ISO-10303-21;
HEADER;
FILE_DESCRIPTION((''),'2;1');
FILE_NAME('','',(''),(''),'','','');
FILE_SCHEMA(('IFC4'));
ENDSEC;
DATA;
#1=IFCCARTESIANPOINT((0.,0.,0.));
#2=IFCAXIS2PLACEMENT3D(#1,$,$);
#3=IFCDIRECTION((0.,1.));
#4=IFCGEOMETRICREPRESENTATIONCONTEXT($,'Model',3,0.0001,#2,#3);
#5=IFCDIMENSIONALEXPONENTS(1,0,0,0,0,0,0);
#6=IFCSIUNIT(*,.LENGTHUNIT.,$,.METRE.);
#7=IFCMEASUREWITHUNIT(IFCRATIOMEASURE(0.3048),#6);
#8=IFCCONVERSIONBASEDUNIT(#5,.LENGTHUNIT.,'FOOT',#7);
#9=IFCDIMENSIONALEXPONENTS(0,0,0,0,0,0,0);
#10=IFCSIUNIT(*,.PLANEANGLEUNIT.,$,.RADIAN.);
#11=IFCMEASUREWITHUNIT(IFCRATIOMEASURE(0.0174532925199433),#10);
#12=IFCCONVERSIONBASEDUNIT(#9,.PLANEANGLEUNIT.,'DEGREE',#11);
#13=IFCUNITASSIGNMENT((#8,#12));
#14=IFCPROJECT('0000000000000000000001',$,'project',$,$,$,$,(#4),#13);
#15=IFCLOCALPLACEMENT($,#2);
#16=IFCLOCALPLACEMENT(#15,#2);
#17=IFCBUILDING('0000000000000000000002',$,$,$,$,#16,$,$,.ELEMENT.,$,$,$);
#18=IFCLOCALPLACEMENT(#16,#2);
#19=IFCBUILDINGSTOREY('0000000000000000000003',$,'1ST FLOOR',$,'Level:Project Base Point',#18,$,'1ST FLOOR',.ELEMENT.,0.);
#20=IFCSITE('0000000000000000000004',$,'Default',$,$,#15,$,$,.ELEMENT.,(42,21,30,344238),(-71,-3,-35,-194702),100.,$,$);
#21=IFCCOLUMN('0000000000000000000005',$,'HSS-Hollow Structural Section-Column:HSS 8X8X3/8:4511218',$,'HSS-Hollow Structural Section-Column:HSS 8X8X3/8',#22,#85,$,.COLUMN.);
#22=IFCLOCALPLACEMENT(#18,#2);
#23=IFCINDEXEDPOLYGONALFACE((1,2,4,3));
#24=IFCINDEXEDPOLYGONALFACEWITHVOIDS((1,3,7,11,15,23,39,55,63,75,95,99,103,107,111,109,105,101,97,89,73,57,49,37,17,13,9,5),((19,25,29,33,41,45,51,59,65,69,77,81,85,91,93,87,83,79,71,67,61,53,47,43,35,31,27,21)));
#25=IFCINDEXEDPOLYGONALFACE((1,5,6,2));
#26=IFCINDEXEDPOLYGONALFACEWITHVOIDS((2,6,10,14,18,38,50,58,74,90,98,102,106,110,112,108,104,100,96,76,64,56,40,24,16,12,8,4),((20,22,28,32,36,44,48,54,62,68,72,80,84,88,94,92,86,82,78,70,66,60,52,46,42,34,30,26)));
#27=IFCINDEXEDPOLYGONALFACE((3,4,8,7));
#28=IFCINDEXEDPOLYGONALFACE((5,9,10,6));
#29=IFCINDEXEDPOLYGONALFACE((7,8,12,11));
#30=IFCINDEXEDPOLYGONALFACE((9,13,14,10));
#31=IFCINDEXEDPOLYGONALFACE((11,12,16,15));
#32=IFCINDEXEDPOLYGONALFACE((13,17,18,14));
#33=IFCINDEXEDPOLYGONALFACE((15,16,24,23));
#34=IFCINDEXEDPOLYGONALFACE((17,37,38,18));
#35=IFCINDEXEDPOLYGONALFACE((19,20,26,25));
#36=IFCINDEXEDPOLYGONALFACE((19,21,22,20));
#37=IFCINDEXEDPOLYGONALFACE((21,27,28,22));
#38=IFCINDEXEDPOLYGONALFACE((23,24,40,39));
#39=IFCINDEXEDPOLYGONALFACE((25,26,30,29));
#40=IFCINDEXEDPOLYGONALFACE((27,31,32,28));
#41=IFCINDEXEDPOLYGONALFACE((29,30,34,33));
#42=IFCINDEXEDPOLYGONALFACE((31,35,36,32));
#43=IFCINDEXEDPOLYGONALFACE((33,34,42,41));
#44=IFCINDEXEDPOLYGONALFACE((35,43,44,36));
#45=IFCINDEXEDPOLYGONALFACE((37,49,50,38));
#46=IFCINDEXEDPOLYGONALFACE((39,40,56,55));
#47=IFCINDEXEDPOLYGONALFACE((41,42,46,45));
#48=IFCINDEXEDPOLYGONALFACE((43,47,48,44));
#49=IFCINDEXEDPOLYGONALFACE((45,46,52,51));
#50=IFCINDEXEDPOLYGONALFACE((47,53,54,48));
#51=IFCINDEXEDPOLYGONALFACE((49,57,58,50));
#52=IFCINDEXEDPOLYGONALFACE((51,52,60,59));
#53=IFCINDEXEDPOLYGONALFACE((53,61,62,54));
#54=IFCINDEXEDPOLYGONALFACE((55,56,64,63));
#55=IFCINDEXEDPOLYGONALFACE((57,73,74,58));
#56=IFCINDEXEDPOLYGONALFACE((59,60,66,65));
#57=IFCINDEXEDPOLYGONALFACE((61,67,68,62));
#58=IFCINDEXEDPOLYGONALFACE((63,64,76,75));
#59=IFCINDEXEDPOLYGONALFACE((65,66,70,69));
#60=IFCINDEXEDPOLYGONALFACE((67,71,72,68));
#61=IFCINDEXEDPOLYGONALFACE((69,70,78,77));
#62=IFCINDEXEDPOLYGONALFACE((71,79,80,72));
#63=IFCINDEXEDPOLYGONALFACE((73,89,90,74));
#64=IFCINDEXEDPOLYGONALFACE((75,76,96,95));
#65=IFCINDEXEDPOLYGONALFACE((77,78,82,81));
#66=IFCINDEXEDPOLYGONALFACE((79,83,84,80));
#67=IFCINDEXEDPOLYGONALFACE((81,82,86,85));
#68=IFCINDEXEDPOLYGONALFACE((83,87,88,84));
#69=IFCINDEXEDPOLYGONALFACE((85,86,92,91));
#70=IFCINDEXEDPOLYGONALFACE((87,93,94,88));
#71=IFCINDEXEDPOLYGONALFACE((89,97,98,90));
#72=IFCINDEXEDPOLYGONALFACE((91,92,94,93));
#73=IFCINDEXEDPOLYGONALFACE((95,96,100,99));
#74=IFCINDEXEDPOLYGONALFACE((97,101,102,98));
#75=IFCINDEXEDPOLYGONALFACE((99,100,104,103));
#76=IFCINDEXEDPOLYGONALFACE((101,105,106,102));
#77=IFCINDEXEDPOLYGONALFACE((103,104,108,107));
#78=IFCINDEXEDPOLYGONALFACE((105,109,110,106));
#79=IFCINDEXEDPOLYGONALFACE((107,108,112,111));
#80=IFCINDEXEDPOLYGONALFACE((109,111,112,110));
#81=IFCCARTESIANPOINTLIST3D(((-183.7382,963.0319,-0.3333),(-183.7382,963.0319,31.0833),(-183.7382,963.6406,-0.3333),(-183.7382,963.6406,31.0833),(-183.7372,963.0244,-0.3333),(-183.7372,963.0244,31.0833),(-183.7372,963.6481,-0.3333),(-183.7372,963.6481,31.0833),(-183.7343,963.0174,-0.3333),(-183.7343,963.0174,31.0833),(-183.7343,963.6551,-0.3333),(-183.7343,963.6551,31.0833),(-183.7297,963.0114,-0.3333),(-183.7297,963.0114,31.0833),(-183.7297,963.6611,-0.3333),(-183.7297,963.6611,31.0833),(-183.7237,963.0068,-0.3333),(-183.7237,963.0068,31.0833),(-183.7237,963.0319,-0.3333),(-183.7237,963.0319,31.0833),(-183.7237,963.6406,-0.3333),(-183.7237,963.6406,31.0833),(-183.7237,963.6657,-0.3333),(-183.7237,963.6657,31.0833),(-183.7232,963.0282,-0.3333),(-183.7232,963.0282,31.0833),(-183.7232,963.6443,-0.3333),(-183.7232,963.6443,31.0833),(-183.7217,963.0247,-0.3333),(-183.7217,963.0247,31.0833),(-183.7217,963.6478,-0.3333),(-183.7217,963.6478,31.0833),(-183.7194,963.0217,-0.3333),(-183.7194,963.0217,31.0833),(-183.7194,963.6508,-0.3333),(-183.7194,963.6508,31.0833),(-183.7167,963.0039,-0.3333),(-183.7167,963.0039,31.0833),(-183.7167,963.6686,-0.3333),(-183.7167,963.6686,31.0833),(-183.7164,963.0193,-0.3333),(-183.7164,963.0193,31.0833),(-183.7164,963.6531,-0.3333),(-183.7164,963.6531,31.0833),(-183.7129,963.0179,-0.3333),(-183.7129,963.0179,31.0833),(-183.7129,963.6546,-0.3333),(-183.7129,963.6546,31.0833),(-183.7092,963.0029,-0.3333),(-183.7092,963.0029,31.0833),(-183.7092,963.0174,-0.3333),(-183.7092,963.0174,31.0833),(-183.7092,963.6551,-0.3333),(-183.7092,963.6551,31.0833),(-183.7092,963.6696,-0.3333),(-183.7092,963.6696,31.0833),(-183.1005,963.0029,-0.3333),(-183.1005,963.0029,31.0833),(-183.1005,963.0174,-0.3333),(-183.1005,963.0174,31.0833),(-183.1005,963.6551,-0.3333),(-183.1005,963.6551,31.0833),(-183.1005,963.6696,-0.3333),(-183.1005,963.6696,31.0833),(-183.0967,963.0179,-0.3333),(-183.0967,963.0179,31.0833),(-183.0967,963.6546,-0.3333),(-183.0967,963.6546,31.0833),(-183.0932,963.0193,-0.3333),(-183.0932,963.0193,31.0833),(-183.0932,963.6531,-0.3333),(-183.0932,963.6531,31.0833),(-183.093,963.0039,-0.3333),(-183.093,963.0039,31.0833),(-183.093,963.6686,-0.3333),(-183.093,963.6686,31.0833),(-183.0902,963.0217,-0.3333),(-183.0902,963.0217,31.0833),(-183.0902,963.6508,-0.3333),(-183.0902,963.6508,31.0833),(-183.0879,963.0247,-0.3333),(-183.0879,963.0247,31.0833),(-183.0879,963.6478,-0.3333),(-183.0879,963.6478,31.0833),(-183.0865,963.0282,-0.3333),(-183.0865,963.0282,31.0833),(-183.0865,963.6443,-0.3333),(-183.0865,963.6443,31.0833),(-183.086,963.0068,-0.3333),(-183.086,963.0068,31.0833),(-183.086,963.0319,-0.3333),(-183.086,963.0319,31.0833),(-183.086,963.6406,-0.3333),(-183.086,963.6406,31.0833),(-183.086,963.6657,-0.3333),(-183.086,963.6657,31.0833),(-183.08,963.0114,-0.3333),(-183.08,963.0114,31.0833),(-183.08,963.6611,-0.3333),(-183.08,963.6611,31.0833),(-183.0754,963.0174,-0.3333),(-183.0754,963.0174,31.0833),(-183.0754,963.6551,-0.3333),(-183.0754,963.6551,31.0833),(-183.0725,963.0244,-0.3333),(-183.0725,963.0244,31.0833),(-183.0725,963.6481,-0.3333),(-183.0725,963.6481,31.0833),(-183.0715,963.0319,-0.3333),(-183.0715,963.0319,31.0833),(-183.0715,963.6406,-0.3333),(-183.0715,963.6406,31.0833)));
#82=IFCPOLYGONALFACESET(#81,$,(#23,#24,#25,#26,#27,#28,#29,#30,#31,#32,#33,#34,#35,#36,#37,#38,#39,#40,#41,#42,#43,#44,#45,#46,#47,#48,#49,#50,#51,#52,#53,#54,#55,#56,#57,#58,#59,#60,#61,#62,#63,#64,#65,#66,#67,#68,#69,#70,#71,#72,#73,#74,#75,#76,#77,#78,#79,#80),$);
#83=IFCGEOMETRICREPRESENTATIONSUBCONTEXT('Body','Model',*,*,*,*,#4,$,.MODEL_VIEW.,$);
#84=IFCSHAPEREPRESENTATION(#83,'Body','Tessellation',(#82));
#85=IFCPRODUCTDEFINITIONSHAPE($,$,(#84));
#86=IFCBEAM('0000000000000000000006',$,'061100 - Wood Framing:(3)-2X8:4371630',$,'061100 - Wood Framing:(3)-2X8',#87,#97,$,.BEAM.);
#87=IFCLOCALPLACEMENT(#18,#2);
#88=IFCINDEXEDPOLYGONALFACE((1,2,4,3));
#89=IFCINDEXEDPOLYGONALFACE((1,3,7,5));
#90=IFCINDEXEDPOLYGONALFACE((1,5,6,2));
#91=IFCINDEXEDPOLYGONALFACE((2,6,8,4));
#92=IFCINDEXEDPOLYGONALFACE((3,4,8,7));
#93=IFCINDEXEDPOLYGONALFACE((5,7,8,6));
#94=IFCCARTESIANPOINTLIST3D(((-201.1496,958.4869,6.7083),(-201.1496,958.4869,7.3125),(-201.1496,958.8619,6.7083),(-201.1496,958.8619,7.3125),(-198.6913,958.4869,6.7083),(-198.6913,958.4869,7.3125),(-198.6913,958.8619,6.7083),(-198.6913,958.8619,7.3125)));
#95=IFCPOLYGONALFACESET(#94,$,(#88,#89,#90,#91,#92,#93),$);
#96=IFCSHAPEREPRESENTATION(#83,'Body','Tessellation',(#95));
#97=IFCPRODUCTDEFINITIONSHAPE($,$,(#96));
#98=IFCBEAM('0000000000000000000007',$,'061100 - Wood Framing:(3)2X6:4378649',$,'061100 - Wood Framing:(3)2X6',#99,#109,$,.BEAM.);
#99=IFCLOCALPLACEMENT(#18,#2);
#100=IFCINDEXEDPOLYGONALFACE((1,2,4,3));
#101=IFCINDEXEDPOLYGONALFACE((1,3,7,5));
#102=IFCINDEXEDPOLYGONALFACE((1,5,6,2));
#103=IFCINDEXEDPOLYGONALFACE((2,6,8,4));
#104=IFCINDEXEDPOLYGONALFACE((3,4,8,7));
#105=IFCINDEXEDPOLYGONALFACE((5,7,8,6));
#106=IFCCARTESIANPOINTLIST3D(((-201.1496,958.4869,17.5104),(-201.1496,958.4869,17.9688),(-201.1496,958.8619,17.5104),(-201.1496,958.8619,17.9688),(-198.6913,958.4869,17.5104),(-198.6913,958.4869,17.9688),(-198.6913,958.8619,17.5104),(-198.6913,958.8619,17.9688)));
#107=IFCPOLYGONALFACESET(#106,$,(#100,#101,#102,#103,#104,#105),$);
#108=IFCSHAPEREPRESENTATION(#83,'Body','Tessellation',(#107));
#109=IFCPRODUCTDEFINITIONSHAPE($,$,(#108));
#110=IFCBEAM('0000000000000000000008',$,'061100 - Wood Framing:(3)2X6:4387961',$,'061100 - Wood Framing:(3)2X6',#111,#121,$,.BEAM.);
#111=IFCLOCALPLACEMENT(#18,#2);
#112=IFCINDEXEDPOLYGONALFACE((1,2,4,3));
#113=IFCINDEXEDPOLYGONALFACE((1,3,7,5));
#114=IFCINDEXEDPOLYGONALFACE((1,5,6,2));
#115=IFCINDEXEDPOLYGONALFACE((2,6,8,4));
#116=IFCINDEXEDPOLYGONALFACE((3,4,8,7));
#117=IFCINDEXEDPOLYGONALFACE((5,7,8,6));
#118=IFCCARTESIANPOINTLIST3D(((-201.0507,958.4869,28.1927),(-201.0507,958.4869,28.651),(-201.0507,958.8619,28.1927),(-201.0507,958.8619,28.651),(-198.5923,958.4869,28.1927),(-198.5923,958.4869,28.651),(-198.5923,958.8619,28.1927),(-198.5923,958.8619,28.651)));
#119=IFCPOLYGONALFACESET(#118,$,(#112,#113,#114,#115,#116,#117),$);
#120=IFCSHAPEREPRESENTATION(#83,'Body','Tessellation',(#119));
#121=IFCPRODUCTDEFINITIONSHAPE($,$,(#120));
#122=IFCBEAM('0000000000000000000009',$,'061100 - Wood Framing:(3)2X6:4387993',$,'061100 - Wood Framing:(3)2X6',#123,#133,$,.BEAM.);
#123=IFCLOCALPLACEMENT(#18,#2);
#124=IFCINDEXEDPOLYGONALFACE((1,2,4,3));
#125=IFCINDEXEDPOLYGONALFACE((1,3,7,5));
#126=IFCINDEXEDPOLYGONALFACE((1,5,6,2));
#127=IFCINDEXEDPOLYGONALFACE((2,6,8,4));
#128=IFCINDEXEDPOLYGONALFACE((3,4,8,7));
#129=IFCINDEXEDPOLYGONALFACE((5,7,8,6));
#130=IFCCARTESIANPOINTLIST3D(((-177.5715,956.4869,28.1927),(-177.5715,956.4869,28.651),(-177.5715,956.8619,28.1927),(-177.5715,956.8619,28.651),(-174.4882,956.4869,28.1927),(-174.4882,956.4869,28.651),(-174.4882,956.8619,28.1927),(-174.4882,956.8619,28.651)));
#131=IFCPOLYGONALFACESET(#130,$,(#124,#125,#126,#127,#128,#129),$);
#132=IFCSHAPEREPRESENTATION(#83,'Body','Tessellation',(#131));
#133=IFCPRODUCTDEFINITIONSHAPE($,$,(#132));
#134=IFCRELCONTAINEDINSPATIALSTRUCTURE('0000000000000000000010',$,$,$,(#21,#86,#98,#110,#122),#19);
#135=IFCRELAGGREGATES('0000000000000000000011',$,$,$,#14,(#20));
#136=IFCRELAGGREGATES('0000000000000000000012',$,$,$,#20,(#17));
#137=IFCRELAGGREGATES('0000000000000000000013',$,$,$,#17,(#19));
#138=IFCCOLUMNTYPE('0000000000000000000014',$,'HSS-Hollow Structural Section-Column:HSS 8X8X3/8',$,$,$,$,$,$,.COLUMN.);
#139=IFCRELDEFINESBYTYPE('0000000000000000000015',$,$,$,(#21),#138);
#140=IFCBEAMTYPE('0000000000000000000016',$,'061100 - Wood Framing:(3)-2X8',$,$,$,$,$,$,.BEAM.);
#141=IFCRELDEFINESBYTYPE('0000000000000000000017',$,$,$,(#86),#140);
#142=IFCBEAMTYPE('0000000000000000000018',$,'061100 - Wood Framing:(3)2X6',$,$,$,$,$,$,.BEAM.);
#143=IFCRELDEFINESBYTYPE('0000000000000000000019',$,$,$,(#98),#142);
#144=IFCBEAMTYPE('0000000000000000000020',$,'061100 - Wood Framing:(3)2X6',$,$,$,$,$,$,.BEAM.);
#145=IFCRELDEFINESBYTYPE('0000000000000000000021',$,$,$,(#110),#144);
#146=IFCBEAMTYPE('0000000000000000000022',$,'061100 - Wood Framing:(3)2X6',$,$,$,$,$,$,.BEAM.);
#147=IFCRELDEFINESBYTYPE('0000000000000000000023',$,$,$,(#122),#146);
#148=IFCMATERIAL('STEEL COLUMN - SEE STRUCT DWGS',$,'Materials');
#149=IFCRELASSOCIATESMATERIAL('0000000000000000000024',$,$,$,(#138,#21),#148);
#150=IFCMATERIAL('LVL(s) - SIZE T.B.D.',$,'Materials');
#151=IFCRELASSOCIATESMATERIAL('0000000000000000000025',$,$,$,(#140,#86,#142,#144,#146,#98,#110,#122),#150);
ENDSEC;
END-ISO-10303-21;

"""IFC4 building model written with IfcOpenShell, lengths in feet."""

from ifc_helpers import new_model, entity, si_unit, converted_unit, direction, frame, frame_2d, origin, place, context, subcontext, project, spatial, polyline, circle_curve, parameter, trimmed, segment, composite_curve, rectangle, outline, extrude, source, transform, mapped, material, material_profile, profile_set, profile_usage, type_object, type_shapes, element, save


model = new_model("IFC4")

# Units and contexts
model_context = context("Model", 3, precision=0.0001, world=origin(), true_north=direction((0.0, 1.0)))
body_context = subcontext(model_context, "Body", "Model", "MODEL_VIEW")
ifc_project = project(units=[converted_unit("LENGTHUNIT", "FOOT", entity("IfcRatioMeasure", 0.3048), si_unit("LENGTHUNIT", "METRE"), dimensions=[1, 0, 0, 0, 0, 0, 0]), converted_unit("PLANEANGLEUNIT", "DEGREE", entity("IfcRatioMeasure", 0.0174532925199433), si_unit("PLANEANGLEUNIT", "RADIAN"), dimensions=[0, 0, 0, 0, 0, 0, 0])], contexts=[model_context])

# Site, building, storey
site_placement = place(None, origin())
site = spatial("IfcSite", under=ifc_project, at=site_placement, Name="Default", CompositionType="ELEMENT", RefLatitude=(42, 21, 30, 344238), RefLongitude=(-71, -3, -35, -194702), RefElevation=100.0)
building_placement = place(site_placement, origin())
building = spatial("IfcBuilding", under=site, at=building_placement, CompositionType="ELEMENT")
storey_placement = place(building_placement, origin())
storey = spatial("IfcBuildingStorey", under=building, at=storey_placement, Name="1ST FLOOR", ObjectType="Level:Project Base Point", LongName="1ST FLOOR", CompositionType="ELEMENT", Elevation=0.0)

# Column
ifc_material_1 = material(Name="STEEL COLUMN - SEE STRUCT DWGS", Category="Materials")
ifc_material_profile_1 = material_profile(ifc_material_1, outline(composite_curve([segment(polyline([(-0.3043, -0.3333), (0.3043, -0.3333)]), True, "CONTINUOUS"), segment(trimmed(circle_curve(frame_2d((0.3043, -0.3043), x_axis=(-1.0, 0.0)), 0.029), [parameter(90.0)], [parameter(180.0)], True, "PARAMETER"), True, "CONTINUOUS"), segment(polyline([(0.3333, -0.3043), (0.3333, 0.3043)]), True, "CONTINUOUS"), segment(trimmed(circle_curve(frame_2d((0.3043, 0.3043), x_axis=(-1.0, 0.0)), 0.029), [parameter(180.0)], [parameter(270.0)], True, "PARAMETER"), True, "CONTINUOUS"), segment(polyline([(0.3043, 0.3333), (-0.3043, 0.3333)]), True, "CONTINUOUS"), segment(trimmed(circle_curve(frame_2d((-0.3043, 0.3043), x_axis=(-1.0, 0.0)), 0.029), [parameter(270.0)], [parameter(360.0)], True, "PARAMETER"), True, "CONTINUOUS"), segment(polyline([(-0.3333, 0.3043), (-0.3333, -0.3043)]), True, "CONTINUOUS"), segment(trimmed(circle_curve(frame_2d((-0.3043, -0.3043), x_axis=(-1.0, 0.0)), 0.029), [parameter(360.0)], [parameter(90.0)], True, "PARAMETER"), True, "CONTINUOUS")], self_intersect=False), holes=[composite_curve([segment(trimmed(circle_curve(frame_2d((-0.3043, -0.3043), x_axis=(-1.0, 0.0)), 0.0145), [parameter(0.0)], [parameter(90.0)], True, "PARAMETER"), False, "CONTINUOUS"), segment(polyline([(-0.3188, -0.3043), (-0.3188, 0.3043)]), True, "CONTINUOUS"), segment(trimmed(circle_curve(frame_2d((-0.3043, 0.3043), x_axis=(-1.0, 0.0)), 0.0145), [parameter(270.0)], [parameter(0.0)], True, "PARAMETER"), False, "CONTINUOUS"), segment(polyline([(-0.3043, 0.3188), (0.3043, 0.3188)]), True, "CONTINUOUS"), segment(trimmed(circle_curve(frame_2d((0.3043, 0.3043), x_axis=(-1.0, 0.0)), 0.0145), [parameter(180.0)], [parameter(270.0)], True, "PARAMETER"), False, "CONTINUOUS"), segment(polyline([(0.3188, 0.3043), (0.3188, -0.3043)]), True, "CONTINUOUS"), segment(trimmed(circle_curve(frame_2d((0.3043, -0.3043), x_axis=(-1.0, 0.0)), 0.0145), [parameter(90.0)], [parameter(180.0)], True, "PARAMETER"), False, "CONTINUOUS"), segment(polyline([(0.3043, -0.3188), (-0.3043, -0.3188)]), True, "CONTINUOUS")], self_intersect=False)]), Name="HSS 8X8X3/8")
ifc_profile_set_1 = profile_set([ifc_material_profile_1], Name="HSS 8X8X3/8")
ifc_profile_usage_1 = profile_usage(ifc_profile_set_1)
column_type = type_object("IfcColumnType", Name="HSS-Hollow Structural Section-Column:HSS 8X8X3/8", PredefinedType="COLUMN", material=ifc_profile_set_1)
shared_shape_1 = source(origin(), body_context, "Body", "SweptSolid", [
    extrude(outline(composite_curve([segment(trimmed(circle_curve(frame_2d((0.3043, -0.3043), x_axis=(1.0, 0.0)), 0.029), [parameter(270.0)], [parameter(0.0)], True, "PARAMETER"), True, "CONTINUOUS"), segment(polyline([(0.3333, -0.3043), (0.3333, 0.3043)]), True, "CONTINUOUS"), segment(trimmed(circle_curve(frame_2d((0.3043, 0.3043), x_axis=(1.0, 0.0)), 0.029), [parameter(0.0)], [parameter(90.0)], True, "PARAMETER"), True, "CONTINUOUS"), segment(polyline([(0.3043, 0.3333), (-0.3043, 0.3333)]), True, "CONTINUOUS"), segment(trimmed(circle_curve(frame_2d((-0.3043, 0.3043), x_axis=(1.0, 0.0)), 0.029), [parameter(90.0)], [parameter(180.0)], True, "PARAMETER"), True, "CONTINUOUS"), segment(polyline([(-0.3333, 0.3043), (-0.3333, -0.3043)]), True, "CONTINUOUS"), segment(trimmed(circle_curve(frame_2d((-0.3043, -0.3043), x_axis=(1.0, 0.0)), 0.029), [parameter(180.0)], [parameter(270.0)], True, "PARAMETER"), True, "CONTINUOUS"), segment(polyline([(-0.3043, -0.3333), (0.3043, -0.3333)]), True, "CONTINUOUS")], self_intersect=False), holes=[composite_curve([segment(polyline([(0.3043, -0.3188), (-0.3043, -0.3188)]), True, "CONTINUOUS"), segment(trimmed(circle_curve(frame_2d((-0.3043, -0.3043), x_axis=(1.0, 0.0)), 0.0145), [parameter(180.0)], [parameter(270.0)], True, "PARAMETER"), False, "CONTINUOUS"), segment(polyline([(-0.3188, -0.3043), (-0.3188, 0.3043)]), True, "CONTINUOUS"), segment(trimmed(circle_curve(frame_2d((-0.3043, 0.3043), x_axis=(1.0, 0.0)), 0.0145), [parameter(90.0)], [parameter(180.0)], True, "PARAMETER"), False, "CONTINUOUS"), segment(polyline([(-0.3043, 0.3188), (0.3043, 0.3188)]), True, "CONTINUOUS"), segment(trimmed(circle_curve(frame_2d((0.3043, 0.3043), x_axis=(1.0, 0.0)), 0.0145), [parameter(0.0)], [parameter(90.0)], True, "PARAMETER"), False, "CONTINUOUS"), segment(polyline([(0.3188, 0.3043), (0.3188, -0.3043)]), True, "CONTINUOUS"), segment(trimmed(circle_curve(frame_2d((0.3043, -0.3043), x_axis=(1.0, 0.0)), 0.0145), [parameter(270.0)], [parameter(0.0)], True, "PARAMETER"), False, "CONTINUOUS")], self_intersect=False)]), frame((0.0, 0.0, -0.3333)), (0.0, 0.0, 1.0), 31.4167),
])
type_shapes(column_type, [shared_shape_1])
column_placement = place(storey_placement, frame((-183.4048, 963.3362, 0.0), z_axis=(0.0, 0.0, 1.0), x_axis=(-1.0, 0.0, 0.0)))
element("IfcColumn", 1, at=column_placement, inside=storey, type_object=column_type, material=ifc_profile_usage_1, Name="HSS-Hollow Structural Section-Column:HSS 8X8X3/8:4511218", ObjectType="HSS-Hollow Structural Section-Column:HSS 8X8X3/8", PredefinedType="COLUMN", context=body_context, shape_type="MappedRepresentation", body=[
    mapped(shared_shape_1, transform((0.0, 0.0, 0.0), scale=1.0)),
])

# Beams
ifc_material_2 = material(Name="LVL(s) - SIZE T.B.D.", Category="Materials")
ifc_material_profile_2 = material_profile(ifc_material_2, rectangle(XDim=0.6042, YDim=0.375, at=frame_2d((0.0, 0.0), x_axis=(1.0, 0.0))), Name="(3)-2X8")
ifc_profile_set_2 = profile_set([ifc_material_profile_2], Name="(3)-2X8")
ifc_profile_usage_2 = profile_usage(ifc_profile_set_2, cardinal=8)
beam_type_1 = type_object("IfcBeamType", Name="061100 - Wood Framing:(3)-2X8", PredefinedType="BEAM", material=ifc_profile_set_2)
shared_shape_2 = source(origin(), body_context, "Body", "SweptSolid", [
    extrude(rectangle(XDim=0.6042, YDim=0.375, at=frame_2d((0.0, 0.0), x_axis=(1.0, 0.0))), frame((-1.2371, 0.0, 0.0), z_axis=(1.0, 0.0, 0.0), x_axis=(0.0, 0.0, -1.0)), (0.0, 0.0, 1.0), 2.4583),
])
type_shapes(beam_type_1, [shared_shape_2])
beam_1_placement = place(storey_placement, frame((-199.9125, 958.6744, 7.0104)))
element("IfcBeam", 2, at=beam_1_placement, inside=storey, type_object=beam_type_1, material=ifc_profile_usage_2, Name="061100 - Wood Framing:(3)-2X8:4371630", ObjectType="061100 - Wood Framing:(3)-2X8", PredefinedType="BEAM", context=body_context, shape_type="MappedRepresentation", body=[
    mapped(shared_shape_2, transform((0.0, 0.0, 0.0), scale=1.0)),
])
ifc_material_profile_3 = material_profile(ifc_material_2, rectangle(XDim=0.4583, YDim=0.375, at=frame_2d((0.0, 0.0), x_axis=(1.0, 0.0))), Name="(3)2X6")
ifc_profile_set_3 = profile_set([ifc_material_profile_3], Name="(3)2X6")
ifc_profile_usage_3 = profile_usage(ifc_profile_set_3, cardinal=8)
beam_type_2 = type_object("IfcBeamType", Name="061100 - Wood Framing:(3)2X6", PredefinedType="BEAM", material=ifc_profile_set_3)
shared_shape_3 = source(origin(), body_context, "Body", "SweptSolid", [
    extrude(rectangle(XDim=0.4583, YDim=0.375, at=frame_2d((0.0, 0.0), x_axis=(1.0, 0.0))), frame((-1.2065, 0.0, 0.0), z_axis=(1.0, 0.0, 0.0), x_axis=(0.0, 0.0, -1.0)), (0.0, 0.0, 1.0), 2.4583),
])
type_shapes(beam_type_2, [shared_shape_3])
beam_2_placement = place(storey_placement, frame((-199.9431, 958.6744, 17.7396)))
element("IfcBeam", 3, at=beam_2_placement, inside=storey, type_object=beam_type_2, material=ifc_profile_usage_3, Name="061100 - Wood Framing:(3)2X6:4378649", ObjectType="061100 - Wood Framing:(3)2X6", PredefinedType="BEAM", context=body_context, shape_type="MappedRepresentation", body=[
    mapped(shared_shape_3, transform((0.0, 0.0, 0.0), scale=1.0)),
])
ifc_profile_usage_4 = profile_usage(ifc_profile_set_3, cardinal=8)
beam_type_3 = type_object("IfcBeamType", Name="061100 - Wood Framing:(3)2X6", PredefinedType="BEAM", material=ifc_profile_set_3)
shared_shape_4 = source(origin(), body_context, "Body", "SweptSolid", [
    extrude(rectangle(XDim=0.4583, YDim=0.375, at=frame_2d((0.0, 0.0), x_axis=(1.0, 0.0))), frame((-1.2312, 0.0, 0.0), z_axis=(1.0, 0.0, 0.0), x_axis=(0.0, 0.0, -1.0)), (0.0, 0.0, 1.0), 2.4583),
])
type_shapes(beam_type_3, [shared_shape_4])
beam_3_placement = place(storey_placement, frame((-199.8195, 958.6744, 28.4219)))
element("IfcBeam", 4, at=beam_3_placement, inside=storey, type_object=beam_type_3, material=ifc_profile_usage_4, Name="061100 - Wood Framing:(3)2X6:4387961", ObjectType="061100 - Wood Framing:(3)2X6", PredefinedType="BEAM", context=body_context, shape_type="MappedRepresentation", body=[
    mapped(shared_shape_4, transform((0.0, 0.0, 0.0), scale=1.0)),
])
ifc_profile_usage_5 = profile_usage(ifc_profile_set_3, cardinal=8)
beam_type_4 = type_object("IfcBeamType", Name="061100 - Wood Framing:(3)2X6", PredefinedType="BEAM", material=ifc_profile_set_3)
shared_shape_5 = source(origin(), body_context, "Body", "SweptSolid", [
    extrude(rectangle(XDim=0.4583, YDim=0.375, at=frame_2d((0.0, 0.0), x_axis=(1.0, 0.0))), frame((-1.5353, 0.0, 0.0), z_axis=(1.0, 0.0, 0.0), x_axis=(0.0, 0.0, -1.0)), (0.0, 0.0, 1.0), 3.0833),
])
type_shapes(beam_type_4, [shared_shape_5])
beam_4_placement = place(storey_placement, frame((-176.0362, 956.6744, 28.4219)))
element("IfcBeam", 5, at=beam_4_placement, inside=storey, type_object=beam_type_4, material=ifc_profile_usage_5, Name="061100 - Wood Framing:(3)2X6:4387993", ObjectType="061100 - Wood Framing:(3)2X6", PredefinedType="BEAM", context=body_context, shape_type="MappedRepresentation", body=[
    mapped(shared_shape_5, transform((0.0, 0.0, 0.0), scale=1.0)),
])

save(model, "model.ifc")
